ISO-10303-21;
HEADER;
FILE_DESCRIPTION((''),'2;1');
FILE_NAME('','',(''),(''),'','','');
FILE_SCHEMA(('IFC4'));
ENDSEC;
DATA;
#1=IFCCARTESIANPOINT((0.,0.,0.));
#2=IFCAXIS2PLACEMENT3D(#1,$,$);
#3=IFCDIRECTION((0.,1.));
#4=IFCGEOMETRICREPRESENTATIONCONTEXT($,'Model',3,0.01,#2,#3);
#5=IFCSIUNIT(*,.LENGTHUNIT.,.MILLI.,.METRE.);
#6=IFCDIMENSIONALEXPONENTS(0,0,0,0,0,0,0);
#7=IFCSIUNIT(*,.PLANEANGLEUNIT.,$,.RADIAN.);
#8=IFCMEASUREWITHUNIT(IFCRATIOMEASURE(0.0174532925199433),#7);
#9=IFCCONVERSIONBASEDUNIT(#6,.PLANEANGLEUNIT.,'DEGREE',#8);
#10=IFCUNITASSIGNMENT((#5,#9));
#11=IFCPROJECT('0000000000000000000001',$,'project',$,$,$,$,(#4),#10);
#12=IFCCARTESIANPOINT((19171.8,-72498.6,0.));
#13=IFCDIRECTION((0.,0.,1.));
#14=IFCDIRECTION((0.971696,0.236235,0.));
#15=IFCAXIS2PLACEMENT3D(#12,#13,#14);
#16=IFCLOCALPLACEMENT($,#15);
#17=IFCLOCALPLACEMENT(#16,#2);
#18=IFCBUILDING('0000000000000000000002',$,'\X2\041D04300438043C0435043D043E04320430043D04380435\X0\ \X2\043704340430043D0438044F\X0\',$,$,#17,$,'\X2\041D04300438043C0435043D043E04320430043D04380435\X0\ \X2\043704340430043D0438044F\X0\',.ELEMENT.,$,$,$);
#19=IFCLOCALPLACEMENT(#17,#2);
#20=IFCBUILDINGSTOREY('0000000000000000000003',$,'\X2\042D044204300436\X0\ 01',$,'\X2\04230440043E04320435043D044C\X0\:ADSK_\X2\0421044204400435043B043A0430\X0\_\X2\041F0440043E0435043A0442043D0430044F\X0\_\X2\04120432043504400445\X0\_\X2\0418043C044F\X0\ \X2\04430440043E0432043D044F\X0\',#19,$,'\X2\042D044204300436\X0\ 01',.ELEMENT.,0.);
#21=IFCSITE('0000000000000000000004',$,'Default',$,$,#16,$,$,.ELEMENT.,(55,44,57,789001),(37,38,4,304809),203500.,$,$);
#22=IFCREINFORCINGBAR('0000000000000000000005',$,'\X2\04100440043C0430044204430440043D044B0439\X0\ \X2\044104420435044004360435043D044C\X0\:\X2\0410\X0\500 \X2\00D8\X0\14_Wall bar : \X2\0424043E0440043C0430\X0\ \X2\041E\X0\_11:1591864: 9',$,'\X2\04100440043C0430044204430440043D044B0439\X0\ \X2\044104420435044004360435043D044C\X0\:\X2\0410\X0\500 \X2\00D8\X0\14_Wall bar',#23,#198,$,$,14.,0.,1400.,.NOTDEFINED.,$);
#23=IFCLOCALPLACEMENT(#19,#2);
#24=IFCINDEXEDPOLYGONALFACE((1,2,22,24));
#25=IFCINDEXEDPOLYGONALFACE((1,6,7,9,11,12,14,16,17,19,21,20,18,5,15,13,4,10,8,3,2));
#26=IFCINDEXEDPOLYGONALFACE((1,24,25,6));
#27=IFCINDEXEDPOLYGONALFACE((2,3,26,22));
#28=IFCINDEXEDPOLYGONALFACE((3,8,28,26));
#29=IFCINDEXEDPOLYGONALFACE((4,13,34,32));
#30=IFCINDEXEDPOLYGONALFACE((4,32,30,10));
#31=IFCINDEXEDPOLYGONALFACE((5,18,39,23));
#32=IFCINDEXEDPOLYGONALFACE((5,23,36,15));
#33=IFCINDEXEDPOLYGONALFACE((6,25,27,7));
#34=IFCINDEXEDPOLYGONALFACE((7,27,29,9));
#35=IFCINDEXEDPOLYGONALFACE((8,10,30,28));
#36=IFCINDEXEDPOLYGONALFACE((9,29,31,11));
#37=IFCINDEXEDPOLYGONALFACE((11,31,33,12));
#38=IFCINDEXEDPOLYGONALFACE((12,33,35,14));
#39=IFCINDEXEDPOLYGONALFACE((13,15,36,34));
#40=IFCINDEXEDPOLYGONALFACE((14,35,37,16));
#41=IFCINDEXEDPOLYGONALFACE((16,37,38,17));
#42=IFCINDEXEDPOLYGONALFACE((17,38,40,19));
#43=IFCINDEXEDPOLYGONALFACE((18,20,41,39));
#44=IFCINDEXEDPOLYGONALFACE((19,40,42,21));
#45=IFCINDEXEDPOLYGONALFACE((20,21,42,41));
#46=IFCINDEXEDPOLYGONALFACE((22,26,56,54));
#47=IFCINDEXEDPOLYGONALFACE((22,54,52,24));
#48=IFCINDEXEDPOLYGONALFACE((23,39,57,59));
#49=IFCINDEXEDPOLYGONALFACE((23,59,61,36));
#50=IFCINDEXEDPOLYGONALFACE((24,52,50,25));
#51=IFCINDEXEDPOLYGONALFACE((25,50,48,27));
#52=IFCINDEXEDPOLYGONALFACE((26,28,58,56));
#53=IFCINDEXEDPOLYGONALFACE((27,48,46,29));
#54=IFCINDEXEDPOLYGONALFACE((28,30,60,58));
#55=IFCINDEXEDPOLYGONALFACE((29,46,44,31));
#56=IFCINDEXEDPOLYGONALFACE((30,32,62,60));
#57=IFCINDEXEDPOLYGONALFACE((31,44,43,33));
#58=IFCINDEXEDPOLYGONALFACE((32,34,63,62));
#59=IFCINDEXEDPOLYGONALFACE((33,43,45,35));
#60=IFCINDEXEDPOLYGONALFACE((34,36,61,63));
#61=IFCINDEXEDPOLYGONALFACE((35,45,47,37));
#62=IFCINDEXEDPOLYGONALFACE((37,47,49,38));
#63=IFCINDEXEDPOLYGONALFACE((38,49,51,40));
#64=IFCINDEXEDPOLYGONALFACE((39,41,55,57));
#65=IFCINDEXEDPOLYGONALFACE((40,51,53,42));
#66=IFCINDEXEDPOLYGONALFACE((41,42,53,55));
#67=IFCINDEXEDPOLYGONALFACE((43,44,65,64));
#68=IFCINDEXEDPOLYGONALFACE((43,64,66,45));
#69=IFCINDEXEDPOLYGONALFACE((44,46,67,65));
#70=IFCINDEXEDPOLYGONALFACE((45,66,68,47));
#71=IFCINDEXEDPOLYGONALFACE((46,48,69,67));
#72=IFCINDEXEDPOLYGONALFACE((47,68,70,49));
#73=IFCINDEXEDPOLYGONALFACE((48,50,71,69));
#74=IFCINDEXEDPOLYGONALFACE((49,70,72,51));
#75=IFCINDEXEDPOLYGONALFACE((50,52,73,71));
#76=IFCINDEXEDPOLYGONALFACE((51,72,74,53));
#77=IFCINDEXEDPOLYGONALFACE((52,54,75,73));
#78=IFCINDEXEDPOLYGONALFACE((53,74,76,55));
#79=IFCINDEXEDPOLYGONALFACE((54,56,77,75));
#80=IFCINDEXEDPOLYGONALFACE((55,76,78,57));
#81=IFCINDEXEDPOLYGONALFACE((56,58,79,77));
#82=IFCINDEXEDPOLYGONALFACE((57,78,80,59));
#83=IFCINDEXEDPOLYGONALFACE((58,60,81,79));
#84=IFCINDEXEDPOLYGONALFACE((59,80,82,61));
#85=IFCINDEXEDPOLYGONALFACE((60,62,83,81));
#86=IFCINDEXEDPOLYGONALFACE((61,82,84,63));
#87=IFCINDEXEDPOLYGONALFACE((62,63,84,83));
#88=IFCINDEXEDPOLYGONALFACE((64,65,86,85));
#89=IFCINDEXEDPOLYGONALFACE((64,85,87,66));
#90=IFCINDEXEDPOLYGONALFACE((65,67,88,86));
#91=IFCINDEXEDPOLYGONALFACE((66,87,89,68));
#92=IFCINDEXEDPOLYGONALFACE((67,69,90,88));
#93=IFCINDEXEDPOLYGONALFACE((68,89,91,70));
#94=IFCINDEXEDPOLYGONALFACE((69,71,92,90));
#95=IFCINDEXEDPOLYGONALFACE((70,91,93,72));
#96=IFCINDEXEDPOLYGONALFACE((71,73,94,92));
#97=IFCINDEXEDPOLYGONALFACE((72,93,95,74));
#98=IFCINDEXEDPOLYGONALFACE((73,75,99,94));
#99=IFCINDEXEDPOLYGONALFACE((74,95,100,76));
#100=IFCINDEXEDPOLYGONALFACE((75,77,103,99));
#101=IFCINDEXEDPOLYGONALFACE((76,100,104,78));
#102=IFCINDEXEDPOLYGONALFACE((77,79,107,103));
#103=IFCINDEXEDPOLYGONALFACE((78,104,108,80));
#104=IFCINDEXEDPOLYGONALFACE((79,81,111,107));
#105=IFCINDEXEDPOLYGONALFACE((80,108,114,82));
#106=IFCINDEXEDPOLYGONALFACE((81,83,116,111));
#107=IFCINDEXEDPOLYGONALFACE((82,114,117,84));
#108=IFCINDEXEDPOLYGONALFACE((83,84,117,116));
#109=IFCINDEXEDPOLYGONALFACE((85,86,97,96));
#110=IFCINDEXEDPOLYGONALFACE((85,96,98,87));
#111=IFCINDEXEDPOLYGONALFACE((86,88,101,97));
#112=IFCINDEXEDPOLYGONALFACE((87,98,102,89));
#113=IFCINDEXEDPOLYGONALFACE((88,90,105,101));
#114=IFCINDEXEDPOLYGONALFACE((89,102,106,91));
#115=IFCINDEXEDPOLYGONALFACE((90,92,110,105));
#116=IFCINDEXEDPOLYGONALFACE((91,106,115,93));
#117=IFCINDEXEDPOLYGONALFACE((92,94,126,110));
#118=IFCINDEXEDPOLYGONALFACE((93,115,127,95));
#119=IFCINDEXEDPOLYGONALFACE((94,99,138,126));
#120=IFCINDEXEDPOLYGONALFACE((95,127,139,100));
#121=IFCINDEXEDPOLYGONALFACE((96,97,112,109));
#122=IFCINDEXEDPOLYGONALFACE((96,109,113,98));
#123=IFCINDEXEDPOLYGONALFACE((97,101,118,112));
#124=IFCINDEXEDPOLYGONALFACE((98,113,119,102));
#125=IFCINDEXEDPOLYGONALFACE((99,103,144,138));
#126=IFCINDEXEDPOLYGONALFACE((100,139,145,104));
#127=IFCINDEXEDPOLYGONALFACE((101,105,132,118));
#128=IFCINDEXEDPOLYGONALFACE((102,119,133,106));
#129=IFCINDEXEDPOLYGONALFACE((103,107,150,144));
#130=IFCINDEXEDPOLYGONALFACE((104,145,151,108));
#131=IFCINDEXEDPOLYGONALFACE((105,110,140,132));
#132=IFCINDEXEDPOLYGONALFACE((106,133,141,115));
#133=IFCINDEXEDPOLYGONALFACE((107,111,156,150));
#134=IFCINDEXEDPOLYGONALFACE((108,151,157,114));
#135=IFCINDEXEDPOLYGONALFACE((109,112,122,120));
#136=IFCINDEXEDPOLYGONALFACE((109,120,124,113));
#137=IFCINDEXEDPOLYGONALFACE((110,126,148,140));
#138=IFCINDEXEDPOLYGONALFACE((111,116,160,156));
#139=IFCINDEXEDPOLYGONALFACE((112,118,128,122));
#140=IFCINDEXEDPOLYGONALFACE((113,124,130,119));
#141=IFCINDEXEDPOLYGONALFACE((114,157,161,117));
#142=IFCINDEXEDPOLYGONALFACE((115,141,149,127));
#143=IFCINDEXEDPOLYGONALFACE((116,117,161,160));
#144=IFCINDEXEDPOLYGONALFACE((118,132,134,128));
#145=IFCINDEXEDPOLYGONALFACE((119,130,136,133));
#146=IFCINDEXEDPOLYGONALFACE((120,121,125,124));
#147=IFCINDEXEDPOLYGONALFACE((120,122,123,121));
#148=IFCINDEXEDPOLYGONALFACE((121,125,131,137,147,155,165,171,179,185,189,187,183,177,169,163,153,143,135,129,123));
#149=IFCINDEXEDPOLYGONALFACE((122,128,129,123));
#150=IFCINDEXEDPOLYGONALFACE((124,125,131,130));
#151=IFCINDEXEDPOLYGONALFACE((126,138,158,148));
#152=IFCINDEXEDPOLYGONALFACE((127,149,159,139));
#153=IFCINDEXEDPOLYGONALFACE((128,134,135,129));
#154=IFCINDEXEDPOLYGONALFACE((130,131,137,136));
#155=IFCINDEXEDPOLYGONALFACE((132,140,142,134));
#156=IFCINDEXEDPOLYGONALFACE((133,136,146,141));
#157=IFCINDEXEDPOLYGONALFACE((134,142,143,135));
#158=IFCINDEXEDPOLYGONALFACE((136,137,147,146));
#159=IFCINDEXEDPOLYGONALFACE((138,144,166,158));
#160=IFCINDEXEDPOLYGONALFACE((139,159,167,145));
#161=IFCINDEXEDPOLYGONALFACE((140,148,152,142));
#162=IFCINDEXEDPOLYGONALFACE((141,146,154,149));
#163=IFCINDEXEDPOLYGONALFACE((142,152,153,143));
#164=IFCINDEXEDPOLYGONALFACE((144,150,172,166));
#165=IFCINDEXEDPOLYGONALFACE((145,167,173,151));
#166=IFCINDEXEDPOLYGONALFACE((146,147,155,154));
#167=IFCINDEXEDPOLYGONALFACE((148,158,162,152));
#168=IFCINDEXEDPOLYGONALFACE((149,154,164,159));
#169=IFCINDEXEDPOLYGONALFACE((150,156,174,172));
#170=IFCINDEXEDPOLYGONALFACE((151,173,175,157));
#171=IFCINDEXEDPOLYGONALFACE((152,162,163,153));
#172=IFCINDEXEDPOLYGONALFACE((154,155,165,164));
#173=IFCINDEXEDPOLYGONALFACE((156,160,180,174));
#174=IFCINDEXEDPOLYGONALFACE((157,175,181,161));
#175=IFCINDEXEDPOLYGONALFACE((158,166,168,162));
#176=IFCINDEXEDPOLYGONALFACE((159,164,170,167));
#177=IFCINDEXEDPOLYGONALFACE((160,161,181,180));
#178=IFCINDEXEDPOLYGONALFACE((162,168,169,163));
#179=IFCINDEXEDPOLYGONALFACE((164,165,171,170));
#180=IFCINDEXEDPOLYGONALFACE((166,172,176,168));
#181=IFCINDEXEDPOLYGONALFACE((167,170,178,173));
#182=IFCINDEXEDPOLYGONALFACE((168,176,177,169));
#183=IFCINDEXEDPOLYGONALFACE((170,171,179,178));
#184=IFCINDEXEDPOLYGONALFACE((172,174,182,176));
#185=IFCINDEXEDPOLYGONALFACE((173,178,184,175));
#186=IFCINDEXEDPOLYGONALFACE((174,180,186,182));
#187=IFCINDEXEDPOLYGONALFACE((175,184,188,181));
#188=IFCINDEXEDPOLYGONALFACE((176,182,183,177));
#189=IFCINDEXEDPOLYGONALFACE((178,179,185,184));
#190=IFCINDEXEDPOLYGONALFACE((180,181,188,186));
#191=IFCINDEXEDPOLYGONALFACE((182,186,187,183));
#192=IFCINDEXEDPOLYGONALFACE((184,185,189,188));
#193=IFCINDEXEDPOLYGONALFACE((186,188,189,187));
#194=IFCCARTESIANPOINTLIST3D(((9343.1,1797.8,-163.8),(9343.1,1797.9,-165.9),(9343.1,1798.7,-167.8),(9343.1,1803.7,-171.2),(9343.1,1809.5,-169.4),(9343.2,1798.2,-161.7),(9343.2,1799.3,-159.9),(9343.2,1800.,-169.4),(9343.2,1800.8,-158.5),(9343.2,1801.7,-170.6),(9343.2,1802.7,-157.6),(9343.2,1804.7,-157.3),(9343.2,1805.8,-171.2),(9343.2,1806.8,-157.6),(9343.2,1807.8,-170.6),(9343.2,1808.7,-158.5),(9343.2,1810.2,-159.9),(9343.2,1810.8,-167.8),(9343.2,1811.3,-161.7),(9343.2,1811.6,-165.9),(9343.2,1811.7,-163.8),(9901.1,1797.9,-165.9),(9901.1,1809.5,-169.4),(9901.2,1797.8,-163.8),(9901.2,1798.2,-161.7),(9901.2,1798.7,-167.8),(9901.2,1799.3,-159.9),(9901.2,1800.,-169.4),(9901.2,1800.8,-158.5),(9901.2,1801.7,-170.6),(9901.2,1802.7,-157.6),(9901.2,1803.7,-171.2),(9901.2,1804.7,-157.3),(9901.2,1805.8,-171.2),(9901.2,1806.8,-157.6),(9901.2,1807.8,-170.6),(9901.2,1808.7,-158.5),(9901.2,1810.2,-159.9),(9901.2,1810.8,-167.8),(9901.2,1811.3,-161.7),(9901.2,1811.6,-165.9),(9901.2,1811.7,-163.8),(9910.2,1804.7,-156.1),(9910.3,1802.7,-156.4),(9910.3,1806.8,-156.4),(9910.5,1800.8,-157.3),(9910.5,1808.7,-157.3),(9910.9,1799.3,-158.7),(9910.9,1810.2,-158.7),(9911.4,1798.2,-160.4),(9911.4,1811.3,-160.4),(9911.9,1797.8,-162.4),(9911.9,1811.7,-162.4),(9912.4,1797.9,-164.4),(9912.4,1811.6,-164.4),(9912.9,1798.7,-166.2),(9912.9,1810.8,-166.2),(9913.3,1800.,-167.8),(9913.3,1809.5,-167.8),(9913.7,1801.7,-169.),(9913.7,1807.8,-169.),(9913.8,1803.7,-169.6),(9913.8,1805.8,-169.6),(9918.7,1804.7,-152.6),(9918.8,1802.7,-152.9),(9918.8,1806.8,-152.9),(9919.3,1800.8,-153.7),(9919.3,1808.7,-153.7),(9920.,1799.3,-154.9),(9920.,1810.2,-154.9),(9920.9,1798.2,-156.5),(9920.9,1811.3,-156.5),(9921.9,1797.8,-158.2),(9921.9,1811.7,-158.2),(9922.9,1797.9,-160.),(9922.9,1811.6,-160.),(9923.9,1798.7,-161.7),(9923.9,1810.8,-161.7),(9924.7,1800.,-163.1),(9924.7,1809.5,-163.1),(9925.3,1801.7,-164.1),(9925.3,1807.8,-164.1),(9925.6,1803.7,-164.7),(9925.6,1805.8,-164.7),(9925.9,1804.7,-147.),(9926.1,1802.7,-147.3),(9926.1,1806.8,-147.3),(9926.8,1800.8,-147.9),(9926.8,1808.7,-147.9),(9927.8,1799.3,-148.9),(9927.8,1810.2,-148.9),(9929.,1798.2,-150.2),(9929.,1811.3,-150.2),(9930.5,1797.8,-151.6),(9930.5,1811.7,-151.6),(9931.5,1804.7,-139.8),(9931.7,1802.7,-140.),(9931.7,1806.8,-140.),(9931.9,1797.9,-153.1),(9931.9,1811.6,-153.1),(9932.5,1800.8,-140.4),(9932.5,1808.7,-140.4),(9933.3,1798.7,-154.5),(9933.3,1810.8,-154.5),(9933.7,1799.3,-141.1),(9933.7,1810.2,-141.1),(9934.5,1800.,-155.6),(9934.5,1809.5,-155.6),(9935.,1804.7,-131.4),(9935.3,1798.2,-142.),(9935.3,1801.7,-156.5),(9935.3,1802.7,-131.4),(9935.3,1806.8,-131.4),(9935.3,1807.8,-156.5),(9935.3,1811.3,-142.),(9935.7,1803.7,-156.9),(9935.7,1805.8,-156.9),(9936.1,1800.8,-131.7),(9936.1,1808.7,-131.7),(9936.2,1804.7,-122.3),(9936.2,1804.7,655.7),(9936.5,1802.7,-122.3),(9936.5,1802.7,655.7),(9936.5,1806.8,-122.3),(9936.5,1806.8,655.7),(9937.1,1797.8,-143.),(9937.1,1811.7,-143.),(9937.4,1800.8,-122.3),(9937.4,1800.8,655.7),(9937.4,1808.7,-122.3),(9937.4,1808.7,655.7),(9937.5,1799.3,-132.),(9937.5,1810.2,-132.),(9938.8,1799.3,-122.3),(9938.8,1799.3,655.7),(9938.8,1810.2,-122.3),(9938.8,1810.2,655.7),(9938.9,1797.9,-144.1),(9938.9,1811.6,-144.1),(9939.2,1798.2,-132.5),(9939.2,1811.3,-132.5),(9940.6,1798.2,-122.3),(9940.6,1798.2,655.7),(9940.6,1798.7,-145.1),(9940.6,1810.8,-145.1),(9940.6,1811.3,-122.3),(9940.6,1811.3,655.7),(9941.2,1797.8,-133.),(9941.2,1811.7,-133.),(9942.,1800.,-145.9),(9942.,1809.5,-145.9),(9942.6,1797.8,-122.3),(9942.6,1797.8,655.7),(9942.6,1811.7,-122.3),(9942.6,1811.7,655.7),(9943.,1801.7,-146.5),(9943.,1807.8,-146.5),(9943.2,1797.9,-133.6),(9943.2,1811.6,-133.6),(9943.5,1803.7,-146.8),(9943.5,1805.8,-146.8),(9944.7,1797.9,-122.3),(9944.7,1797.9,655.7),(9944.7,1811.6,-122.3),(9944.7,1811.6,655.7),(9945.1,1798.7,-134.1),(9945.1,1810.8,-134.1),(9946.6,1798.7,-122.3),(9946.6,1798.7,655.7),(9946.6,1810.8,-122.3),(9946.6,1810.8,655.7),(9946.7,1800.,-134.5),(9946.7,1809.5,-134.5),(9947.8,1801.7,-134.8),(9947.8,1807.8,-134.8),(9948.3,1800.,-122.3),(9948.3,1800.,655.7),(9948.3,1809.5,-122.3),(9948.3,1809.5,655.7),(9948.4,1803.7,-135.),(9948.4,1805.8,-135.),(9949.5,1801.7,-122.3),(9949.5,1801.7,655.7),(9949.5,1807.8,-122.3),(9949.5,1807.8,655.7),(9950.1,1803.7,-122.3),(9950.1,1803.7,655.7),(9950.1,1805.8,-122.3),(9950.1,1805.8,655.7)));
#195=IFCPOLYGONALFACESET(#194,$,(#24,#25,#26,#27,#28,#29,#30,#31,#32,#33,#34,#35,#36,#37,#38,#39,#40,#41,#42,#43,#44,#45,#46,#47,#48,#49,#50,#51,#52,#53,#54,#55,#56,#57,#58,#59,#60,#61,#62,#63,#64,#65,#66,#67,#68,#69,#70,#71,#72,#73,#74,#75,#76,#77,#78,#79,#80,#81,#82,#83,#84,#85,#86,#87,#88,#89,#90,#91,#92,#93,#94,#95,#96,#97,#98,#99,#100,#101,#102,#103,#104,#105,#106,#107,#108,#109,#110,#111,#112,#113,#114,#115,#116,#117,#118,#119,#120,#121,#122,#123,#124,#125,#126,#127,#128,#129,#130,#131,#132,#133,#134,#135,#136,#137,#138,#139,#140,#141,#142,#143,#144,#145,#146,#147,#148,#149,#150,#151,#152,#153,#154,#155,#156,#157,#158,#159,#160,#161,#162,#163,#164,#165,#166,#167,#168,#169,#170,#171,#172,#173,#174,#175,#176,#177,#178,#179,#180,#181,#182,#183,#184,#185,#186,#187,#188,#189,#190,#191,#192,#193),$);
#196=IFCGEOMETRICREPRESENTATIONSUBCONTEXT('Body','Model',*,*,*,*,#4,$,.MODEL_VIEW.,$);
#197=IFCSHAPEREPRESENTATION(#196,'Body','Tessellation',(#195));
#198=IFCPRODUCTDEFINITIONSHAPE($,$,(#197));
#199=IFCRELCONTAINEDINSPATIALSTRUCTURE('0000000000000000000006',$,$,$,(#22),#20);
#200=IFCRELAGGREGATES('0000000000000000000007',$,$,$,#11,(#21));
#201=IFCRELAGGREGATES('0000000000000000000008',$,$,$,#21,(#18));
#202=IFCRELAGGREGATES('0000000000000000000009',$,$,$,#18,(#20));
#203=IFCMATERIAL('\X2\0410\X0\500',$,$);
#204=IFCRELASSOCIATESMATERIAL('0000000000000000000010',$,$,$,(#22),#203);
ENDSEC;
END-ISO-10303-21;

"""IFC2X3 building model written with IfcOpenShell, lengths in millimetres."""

from ifc_helpers import new_model, entity, si_unit, converted_unit, direction, frame, origin, place, context, subcontext, project, spatial, material, element, save


model = new_model("IFC2X3")

# Units and contexts
model_context = context("Model", 3, precision=0.01, world=origin(), true_north=direction((0.0, 1.0)))
body_context = subcontext(model_context, "Body", "Model", "MODEL_VIEW")
ifc_project = project(units=[si_unit("LENGTHUNIT", "METRE", prefix="MILLI"), converted_unit("PLANEANGLEUNIT", "DEGREE", entity("IfcRatioMeasure", 0.0174532925199433), si_unit("PLANEANGLEUNIT", "RADIAN"), dimensions=[0, 0, 0, 0, 0, 0, 0])], contexts=[model_context])

# Site, building, storey
site_placement = place(None, frame((19171.8, -72498.6, 0.0), z_axis=(0.0, 0.0, 1.0), x_axis=(0.971696, 0.236235, 0.0)))
site = spatial("IfcSite", under=ifc_project, at=site_placement, Name="Default", CompositionType="ELEMENT", RefLatitude=(55, 44, 57, 789001), RefLongitude=(37, 38, 4, 304809), RefElevation=203500.0)
building_placement = place(site_placement, origin())
building = spatial("IfcBuilding", under=site, at=building_placement, Name="Наименование здания", LongName="Наименование здания", CompositionType="ELEMENT")
storey_placement = place(building_placement, origin())
storey = spatial("IfcBuildingStorey", under=building, at=storey_placement, Name="Этаж 01", ObjectType="Уровень:ADSK_Стрелка_Проектная_Вверх_Имя уровня", LongName="Этаж 01", CompositionType="ELEMENT", Elevation=0.0)

# Reinforcing bar
ifc_material = material(Name="А500")
placement = place(storey_placement, origin())
element("IfcReinforcingBar", 1, at=placement, inside=storey, material=ifc_material, Name="Арматурный стержень:А500 Ø14_Wall bar : Форма О_11:1591864: 9", ObjectType="Арматурный стержень:А500 Ø14_Wall bar", BarLength=1400.0, BarRole="NOTDEFINED", CrossSectionArea=0.0, NominalDiameter=14.0, context=body_context, shape_type="AdvancedSweptSolid", body=[
    entity("IfcSweptDiskSolid", entity("IfcCompositeCurve", [entity("IfcCompositeCurveSegment", "CONTINUOUS", True, entity("IfcPolyline", [entity("IfcCartesianPoint", [9943.1, 1804.7, 655.7]), entity("IfcCartesianPoint", [9943.1, 1804.7, -122.3])])), entity("IfcCompositeCurveSegment", "CONTINUOUS", True, entity("IfcTrimmedCurve", entity("IfcCircle", entity("IfcAxis2Placement3D", entity("IfcCartesianPoint", [9901.1, 1804.7, -122.3]), entity("IfcDirection", [0.0, 1.0, 0.0]), entity("IfcDirection", [0.0, 0.0, -1.0])), 42.0), [entity("IfcParameterValue", 270.0)], [entity("IfcParameterValue", 360.0)], True, "PARAMETER")), entity("IfcCompositeCurveSegment", "CONTINUOUS", True, entity("IfcPolyline", [entity("IfcCartesianPoint", [9901.1, 1804.7, -164.3]), entity("IfcCartesianPoint", [9343.1, 1804.7, -164.3])]))], False), 7.0, None, 0.0, 92.0),
])

save(model, "model.ifc")
